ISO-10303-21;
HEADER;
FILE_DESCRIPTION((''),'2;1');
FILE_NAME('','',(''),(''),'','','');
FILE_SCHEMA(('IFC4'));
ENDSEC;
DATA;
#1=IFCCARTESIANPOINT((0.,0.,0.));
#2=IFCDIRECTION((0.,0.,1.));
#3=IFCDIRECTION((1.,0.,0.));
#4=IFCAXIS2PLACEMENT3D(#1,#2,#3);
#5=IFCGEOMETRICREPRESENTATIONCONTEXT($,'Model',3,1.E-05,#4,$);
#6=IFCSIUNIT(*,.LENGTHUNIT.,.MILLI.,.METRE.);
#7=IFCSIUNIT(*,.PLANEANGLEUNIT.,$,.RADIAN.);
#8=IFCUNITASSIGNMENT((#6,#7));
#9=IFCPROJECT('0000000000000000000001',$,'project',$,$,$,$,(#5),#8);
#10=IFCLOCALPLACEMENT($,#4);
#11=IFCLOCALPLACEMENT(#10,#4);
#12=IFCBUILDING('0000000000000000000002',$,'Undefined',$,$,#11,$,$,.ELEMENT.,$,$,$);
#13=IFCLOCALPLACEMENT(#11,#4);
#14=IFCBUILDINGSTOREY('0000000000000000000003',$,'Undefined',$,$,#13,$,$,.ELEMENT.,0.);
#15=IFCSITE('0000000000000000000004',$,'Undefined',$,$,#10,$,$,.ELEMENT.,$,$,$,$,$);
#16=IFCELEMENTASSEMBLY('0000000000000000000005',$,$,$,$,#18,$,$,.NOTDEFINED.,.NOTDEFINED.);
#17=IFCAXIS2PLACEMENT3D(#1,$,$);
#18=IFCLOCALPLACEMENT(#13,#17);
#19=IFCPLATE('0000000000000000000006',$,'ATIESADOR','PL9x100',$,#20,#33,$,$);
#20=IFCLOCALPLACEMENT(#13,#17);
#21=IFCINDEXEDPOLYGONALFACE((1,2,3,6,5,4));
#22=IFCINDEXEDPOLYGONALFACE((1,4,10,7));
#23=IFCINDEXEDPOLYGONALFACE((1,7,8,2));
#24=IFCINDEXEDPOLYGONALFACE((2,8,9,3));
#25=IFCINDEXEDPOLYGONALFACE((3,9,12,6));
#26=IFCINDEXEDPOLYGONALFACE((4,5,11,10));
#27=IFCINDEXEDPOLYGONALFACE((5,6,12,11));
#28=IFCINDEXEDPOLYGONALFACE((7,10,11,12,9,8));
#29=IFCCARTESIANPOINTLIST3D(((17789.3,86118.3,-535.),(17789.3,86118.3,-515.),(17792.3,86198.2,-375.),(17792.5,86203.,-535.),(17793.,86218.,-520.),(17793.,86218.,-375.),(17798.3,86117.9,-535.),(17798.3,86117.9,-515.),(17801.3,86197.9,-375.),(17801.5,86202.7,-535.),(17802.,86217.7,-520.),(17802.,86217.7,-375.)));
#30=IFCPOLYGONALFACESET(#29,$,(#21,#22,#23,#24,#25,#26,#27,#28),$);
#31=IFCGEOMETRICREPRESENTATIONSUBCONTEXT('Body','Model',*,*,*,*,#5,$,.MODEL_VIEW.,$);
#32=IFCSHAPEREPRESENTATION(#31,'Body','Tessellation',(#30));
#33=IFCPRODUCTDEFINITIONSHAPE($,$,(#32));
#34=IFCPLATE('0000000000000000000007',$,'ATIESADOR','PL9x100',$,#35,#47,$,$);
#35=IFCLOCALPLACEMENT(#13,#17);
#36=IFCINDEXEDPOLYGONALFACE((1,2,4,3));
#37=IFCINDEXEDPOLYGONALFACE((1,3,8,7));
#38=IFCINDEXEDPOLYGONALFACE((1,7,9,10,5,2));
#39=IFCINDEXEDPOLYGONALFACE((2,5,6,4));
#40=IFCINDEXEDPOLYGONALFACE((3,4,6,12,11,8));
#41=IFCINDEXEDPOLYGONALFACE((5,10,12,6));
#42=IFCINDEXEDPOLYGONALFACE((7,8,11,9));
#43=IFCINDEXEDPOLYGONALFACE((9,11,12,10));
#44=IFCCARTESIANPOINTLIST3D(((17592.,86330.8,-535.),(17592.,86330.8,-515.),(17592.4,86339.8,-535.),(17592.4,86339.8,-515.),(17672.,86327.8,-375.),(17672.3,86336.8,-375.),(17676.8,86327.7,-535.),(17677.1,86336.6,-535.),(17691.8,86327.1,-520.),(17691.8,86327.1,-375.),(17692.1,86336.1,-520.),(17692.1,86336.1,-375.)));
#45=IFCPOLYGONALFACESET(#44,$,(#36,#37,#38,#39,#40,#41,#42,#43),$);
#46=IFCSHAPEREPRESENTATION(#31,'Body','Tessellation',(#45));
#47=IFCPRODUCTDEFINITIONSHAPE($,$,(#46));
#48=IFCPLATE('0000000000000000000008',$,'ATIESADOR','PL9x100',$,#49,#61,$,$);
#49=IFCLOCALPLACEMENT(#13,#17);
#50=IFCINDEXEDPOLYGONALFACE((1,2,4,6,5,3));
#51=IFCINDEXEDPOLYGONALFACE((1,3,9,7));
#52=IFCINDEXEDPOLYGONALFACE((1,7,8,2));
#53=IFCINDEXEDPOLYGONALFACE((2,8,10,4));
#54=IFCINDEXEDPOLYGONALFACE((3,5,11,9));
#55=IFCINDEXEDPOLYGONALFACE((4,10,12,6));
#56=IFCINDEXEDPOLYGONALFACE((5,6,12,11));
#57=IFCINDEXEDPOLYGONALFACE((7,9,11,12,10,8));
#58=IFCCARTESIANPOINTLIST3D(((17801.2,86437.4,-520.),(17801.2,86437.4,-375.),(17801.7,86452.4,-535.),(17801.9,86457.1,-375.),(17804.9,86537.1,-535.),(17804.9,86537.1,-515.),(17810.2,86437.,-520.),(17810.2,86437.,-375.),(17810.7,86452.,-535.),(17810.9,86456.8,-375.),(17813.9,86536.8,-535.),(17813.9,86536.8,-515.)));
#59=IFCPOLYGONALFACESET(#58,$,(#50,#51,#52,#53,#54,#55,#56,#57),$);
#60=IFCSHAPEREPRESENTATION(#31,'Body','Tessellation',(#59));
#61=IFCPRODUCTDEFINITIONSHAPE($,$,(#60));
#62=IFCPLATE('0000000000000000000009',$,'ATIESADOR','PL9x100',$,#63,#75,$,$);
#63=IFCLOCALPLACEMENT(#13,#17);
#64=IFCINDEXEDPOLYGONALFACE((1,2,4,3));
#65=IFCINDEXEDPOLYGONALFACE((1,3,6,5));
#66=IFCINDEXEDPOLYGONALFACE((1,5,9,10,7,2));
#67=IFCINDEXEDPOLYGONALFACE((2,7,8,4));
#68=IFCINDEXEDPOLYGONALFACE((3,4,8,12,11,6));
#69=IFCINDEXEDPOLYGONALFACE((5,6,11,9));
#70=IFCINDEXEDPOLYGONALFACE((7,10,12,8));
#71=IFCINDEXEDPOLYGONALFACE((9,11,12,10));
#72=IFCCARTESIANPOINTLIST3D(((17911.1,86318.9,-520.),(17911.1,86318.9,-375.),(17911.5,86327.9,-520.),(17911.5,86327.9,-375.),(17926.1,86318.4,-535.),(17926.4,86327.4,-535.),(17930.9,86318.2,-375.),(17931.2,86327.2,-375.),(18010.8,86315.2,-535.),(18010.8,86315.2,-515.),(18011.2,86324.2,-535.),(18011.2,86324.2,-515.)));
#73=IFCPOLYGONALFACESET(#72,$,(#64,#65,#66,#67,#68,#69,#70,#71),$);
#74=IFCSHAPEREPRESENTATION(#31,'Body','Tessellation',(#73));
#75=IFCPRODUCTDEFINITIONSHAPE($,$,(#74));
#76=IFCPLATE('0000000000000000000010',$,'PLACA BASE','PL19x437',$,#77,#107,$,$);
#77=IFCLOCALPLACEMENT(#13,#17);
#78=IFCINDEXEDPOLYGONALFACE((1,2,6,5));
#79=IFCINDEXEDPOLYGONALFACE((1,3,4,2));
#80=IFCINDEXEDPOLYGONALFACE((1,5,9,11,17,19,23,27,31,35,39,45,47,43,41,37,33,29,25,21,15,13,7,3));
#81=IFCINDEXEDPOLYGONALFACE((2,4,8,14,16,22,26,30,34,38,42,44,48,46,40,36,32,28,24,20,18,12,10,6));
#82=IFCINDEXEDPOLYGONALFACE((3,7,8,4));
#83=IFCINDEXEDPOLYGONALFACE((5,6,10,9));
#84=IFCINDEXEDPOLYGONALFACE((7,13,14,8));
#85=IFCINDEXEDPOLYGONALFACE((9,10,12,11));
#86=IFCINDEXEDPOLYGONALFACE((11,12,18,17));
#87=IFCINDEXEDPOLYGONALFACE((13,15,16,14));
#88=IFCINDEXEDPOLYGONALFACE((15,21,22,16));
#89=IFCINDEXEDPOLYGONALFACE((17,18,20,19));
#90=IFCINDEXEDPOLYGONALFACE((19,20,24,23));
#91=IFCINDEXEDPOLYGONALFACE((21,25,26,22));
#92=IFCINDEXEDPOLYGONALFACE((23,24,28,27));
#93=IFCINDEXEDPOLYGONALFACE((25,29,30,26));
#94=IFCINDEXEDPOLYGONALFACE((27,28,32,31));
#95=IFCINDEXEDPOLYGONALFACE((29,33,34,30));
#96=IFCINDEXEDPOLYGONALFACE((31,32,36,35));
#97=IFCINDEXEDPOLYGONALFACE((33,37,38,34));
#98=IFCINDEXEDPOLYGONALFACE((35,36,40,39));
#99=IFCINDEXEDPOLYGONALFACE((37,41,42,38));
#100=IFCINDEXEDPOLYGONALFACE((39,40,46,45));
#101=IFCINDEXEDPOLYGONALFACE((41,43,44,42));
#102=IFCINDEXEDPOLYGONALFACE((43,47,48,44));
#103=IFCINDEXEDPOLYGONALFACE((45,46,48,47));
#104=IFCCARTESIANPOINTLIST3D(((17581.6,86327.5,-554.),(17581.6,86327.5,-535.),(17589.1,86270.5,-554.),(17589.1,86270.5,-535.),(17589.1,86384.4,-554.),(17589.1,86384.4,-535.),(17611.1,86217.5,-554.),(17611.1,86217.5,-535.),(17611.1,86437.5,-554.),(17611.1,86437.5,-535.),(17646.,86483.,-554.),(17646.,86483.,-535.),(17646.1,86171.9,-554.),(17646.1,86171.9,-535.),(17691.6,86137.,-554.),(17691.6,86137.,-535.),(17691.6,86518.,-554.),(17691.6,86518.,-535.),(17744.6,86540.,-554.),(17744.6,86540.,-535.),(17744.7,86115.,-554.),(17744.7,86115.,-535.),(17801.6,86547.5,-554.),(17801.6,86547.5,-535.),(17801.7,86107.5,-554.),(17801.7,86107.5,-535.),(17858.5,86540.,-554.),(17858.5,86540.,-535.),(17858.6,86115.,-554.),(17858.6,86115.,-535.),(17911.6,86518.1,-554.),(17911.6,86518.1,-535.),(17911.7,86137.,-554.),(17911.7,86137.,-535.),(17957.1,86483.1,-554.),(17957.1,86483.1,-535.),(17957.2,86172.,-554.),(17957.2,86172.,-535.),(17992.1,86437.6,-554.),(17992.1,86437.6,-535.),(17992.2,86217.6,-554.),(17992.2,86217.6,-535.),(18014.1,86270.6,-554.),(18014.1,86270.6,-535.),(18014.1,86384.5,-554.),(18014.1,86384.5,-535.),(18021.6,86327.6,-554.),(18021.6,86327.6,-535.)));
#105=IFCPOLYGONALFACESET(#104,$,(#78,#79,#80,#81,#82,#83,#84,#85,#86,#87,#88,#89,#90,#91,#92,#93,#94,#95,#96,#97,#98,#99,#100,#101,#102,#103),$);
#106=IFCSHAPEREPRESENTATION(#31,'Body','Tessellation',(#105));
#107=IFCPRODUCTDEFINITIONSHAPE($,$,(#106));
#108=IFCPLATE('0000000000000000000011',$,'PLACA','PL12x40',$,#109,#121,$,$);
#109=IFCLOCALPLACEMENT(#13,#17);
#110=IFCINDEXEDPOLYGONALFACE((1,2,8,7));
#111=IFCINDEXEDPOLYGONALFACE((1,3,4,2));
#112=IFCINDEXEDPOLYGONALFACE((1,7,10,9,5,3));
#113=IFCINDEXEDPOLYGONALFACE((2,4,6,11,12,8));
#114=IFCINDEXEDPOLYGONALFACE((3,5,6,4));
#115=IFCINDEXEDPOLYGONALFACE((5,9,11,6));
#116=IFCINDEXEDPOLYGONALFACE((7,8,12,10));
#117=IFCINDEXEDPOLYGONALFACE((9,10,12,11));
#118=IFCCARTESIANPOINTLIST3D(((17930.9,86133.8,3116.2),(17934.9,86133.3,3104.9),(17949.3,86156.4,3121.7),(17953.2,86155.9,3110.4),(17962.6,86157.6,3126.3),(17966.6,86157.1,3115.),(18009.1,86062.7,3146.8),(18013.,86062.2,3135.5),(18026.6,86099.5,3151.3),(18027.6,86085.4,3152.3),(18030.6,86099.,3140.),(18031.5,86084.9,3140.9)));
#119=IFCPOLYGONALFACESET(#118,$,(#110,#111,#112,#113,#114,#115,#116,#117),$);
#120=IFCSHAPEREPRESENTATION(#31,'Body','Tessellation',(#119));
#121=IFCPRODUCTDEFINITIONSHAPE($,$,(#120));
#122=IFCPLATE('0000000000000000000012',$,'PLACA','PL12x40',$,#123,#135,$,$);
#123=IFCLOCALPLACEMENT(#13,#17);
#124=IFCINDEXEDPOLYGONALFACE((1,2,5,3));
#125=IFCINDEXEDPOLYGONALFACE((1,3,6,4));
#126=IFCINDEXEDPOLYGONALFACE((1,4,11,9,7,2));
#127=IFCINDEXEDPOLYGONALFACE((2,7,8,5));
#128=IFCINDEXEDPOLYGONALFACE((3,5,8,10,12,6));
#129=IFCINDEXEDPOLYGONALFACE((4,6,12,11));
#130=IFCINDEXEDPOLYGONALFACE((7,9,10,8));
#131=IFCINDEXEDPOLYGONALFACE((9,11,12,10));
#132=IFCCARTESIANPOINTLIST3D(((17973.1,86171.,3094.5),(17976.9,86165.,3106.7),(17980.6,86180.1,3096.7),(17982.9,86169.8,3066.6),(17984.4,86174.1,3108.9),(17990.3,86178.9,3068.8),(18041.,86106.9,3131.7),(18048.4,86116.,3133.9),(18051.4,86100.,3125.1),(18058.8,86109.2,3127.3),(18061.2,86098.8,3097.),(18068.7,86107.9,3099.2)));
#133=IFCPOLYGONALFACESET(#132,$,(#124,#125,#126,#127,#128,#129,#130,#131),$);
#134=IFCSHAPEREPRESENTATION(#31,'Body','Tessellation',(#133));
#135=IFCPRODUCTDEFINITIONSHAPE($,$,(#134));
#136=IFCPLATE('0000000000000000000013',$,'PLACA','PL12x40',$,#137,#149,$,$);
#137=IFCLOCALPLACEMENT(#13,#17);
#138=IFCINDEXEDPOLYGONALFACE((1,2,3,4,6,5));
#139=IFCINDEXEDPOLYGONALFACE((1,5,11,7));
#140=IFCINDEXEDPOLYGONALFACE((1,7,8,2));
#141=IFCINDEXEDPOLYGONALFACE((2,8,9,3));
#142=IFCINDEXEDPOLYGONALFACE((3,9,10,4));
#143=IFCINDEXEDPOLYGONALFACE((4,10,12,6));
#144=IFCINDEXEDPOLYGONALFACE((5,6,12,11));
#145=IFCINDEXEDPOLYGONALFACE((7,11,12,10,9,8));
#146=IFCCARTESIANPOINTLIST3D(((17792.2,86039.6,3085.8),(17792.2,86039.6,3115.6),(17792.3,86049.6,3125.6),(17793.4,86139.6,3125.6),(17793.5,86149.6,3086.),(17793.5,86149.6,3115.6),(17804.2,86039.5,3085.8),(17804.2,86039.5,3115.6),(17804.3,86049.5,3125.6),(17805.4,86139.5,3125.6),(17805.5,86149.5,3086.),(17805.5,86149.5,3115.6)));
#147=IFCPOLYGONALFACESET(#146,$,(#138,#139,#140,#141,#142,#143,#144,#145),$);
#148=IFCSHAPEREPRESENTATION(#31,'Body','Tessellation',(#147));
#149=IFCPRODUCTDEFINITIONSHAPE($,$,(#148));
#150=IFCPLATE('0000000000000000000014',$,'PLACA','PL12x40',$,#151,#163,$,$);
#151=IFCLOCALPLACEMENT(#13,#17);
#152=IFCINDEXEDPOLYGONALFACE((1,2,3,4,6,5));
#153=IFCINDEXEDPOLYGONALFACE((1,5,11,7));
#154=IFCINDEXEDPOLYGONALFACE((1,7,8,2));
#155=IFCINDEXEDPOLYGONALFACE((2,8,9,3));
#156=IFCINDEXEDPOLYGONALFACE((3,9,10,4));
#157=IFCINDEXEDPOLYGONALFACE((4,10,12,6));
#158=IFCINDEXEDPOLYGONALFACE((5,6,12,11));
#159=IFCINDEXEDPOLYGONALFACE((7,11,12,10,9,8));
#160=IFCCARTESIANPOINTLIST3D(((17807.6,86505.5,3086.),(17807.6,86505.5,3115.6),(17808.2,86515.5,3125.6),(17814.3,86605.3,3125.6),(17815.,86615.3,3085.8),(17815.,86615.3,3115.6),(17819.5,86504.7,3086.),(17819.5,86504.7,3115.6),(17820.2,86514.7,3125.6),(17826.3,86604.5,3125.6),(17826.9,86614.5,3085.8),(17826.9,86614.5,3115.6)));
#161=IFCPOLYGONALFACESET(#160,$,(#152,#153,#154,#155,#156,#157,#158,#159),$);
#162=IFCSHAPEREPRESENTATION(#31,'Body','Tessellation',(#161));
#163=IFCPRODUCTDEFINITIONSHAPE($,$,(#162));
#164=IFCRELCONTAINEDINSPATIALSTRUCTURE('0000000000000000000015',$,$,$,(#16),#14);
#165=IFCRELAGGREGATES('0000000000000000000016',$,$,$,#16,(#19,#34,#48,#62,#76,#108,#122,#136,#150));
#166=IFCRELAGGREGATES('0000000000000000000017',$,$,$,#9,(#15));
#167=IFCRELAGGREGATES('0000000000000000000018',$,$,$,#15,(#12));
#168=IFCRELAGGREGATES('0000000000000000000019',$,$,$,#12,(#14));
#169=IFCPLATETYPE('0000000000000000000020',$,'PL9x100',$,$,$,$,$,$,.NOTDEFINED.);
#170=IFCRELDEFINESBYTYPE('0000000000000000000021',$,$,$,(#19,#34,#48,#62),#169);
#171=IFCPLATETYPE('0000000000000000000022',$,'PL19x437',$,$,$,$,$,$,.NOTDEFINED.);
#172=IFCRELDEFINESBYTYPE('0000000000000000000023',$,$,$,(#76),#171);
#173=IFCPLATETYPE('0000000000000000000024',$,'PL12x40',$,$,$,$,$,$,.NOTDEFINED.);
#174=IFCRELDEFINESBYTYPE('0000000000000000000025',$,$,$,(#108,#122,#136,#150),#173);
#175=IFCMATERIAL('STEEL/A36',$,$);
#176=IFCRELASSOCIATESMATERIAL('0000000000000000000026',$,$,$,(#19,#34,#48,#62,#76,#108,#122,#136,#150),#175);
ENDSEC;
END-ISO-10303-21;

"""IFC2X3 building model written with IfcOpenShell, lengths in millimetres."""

from ifc_helpers import new_model, si_unit, frame, frame_2d, origin_with_axes, place, context, subcontext, project, spatial, polyline, circle_curve, parameter, trimmed, segment, composite_curve, outline, extrude, material, type_object, element, aggregate, save


model = new_model("IFC2X3")

# Units and contexts
model_context = context("Model", 3, precision=1e-05, world=origin_with_axes())
body_context = subcontext(model_context, "Body", "Model", "MODEL_VIEW")
ifc_project = project(units=[si_unit("LENGTHUNIT", "METRE", prefix="MILLI"), si_unit("PLANEANGLEUNIT", "RADIAN")], contexts=[model_context])

# Site, building, storey
site_placement = place(None, origin_with_axes())
site = spatial("IfcSite", under=ifc_project, at=site_placement, Name="Undefined", CompositionType="ELEMENT")
building_placement = place(site_placement, origin_with_axes())
building = spatial("IfcBuilding", under=site, at=building_placement, Name="Undefined", CompositionType="ELEMENT")
storey_placement = place(building_placement, origin_with_axes())
storey = spatial("IfcBuildingStorey", under=building, at=storey_placement, Name="Undefined", CompositionType="ELEMENT", Elevation=0.0)

# Element assembly, plates
assembly_1_placement = place(storey_placement, origin_with_axes())
assembly_1 = element("IfcElementAssembly", 1, at=assembly_1_placement, inside=storey, AssemblyPlace="NOTDEFINED", PredefinedType="NOTDEFINED")
ifc_material_1 = material(Name="STEEL/A36")
plate_type_1 = type_object("IfcPlateType", Name="PL9x100", PredefinedType="NOTDEFINED")
plate_1_placement = place(assembly_1_placement, frame((17793.8, 86118.1, -515.0), z_axis=(0.999309, -0.037178, 0.0), x_axis=(0.0, 0.0, -1.0)))
plate_1 = element("IfcPlate", 2, at=plate_1_placement, type_object=plate_type_1, material=ifc_material_1, Name="ATIESADOR", Description="PL9x100", context=body_context, shape_type="SweptSolid", body=[
    extrude(outline(polyline([(0.0, 0.0), (20.0, 0.0), (20.0, 84.8), (5.0, 99.8), (-140.0, 99.8), (-140.0, 80.0), (0.0, 0.0)])), frame((0.0, 0.0, -4.5), z_axis=(0.0, 0.0, 1.0), x_axis=(1.0, 0.0, 0.0)), (0.0, 0.0, 1.0), 9.0),
])
plate_2_placement = place(assembly_1_placement, frame((17592.2, 86335.3, -515.0), z_axis=(-0.037178, -0.999309, 0.0), x_axis=(0.0, 0.0, -1.0)))
plate_2 = element("IfcPlate", 3, at=plate_2_placement, type_object=plate_type_1, material=ifc_material_1, Name="ATIESADOR", Description="PL9x100", context=body_context, shape_type="SweptSolid", body=[
    extrude(outline(polyline([(0.0, 0.0), (20.0, 0.0), (20.0, 84.8), (5.0, 99.8), (-140.0, 99.8), (-140.0, 80.0), (0.0, 0.0)])), frame((0.0, 0.0, -4.5), z_axis=(0.0, 0.0, 1.0), x_axis=(1.0, 0.0, 0.0)), (0.0, 0.0, 1.0), 9.0),
])
plate_3_placement = place(assembly_1_placement, frame((17809.4, 86536.9, -515.0), z_axis=(-0.999309, 0.037178, 0.0), x_axis=(0.0, 0.0, -1.0)))
plate_3 = element("IfcPlate", 4, at=plate_3_placement, type_object=plate_type_1, material=ifc_material_1, Name="ATIESADOR", Description="PL9x100", context=body_context, shape_type="SweptSolid", body=[
    extrude(outline(polyline([(0.0, 0.0), (20.0, 0.0), (20.0, 84.8), (5.0, 99.8), (-140.0, 99.8), (-140.0, 80.0), (0.0, 0.0)])), frame((0.0, 0.0, -4.5), z_axis=(0.0, 0.0, 1.0), x_axis=(1.0, 0.0, 0.0)), (0.0, 0.0, 1.0), 9.0),
])
plate_4_placement = place(assembly_1_placement, frame((18011.0, 86319.7, -515.0), z_axis=(0.037178, 0.999309, 0.0), x_axis=(0.0, 0.0, -1.0)))
plate_4 = element("IfcPlate", 5, at=plate_4_placement, type_object=plate_type_1, material=ifc_material_1, Name="ATIESADOR", Description="PL9x100", context=body_context, shape_type="SweptSolid", body=[
    extrude(outline(polyline([(0.0, 0.0), (20.0, 0.0), (20.0, 84.8), (5.0, 99.8), (-140.0, 99.8), (-140.0, 80.0), (0.0, 0.0)])), frame((0.0, 0.0, -4.5), z_axis=(0.0, 0.0, 1.0), x_axis=(1.0, 0.0, 0.0)), (0.0, 0.0, 1.0), 9.0),
])
plate_type_2 = type_object("IfcPlateType", Name="PL19x437", PredefinedType="NOTDEFINED")
plate_5_placement = place(assembly_1_placement, frame((17858.5, 86540.0, -544.5), z_axis=(0.0, 0.0, 1.0), x_axis=(-0.865912, -0.500196, 0.0)))
plate_5 = element("IfcPlate", 6, at=plate_5_placement, type_object=plate_type_2, material=ifc_material_1, Name="PLACA BASE", Description="PL19x437", context=body_context, shape_type="SweptSolid", body=[
    extrude(outline(composite_curve([segment(trimmed(circle_curve(frame_2d((155.6, 155.6), x_axis=(-1.0, 0.000003)), 220.0), [parameter(0.0)], [parameter(1.570799)], True, "PARAMETER"), True, "CONTINUOUS"), segment(trimmed(circle_curve(frame_2d((155.6, 155.6), x_axis=(0.0, -1.0)), 220.0), [parameter(0.0)], [parameter(1.570794)], True, "PARAMETER"), True, "CONTINUOUS"), segment(trimmed(circle_curve(frame_2d((155.6, 155.6), x_axis=(1.0, -0.000003)), 220.0), [parameter(0.0)], [parameter(1.5708)], True, "PARAMETER"), True, "CONTINUOUS"), segment(trimmed(circle_curve(frame_2d((155.6, 155.6), x_axis=(-0.000001, 1.0)), 220.0), [parameter(0.0)], [parameter(1.570793)], True, "PARAMETER"), True, "DISCONTINUOUS")], self_intersect=True)), frame((0.0, 0.0, -9.5), z_axis=(0.0, 0.0, 1.0), x_axis=(1.0, 0.0, 0.0)), (0.0, 0.0, 1.0), 19.0),
])
plate_type_3 = type_object("IfcPlateType", Name="PL12x40", PredefinedType="NOTDEFINED")
plate_6_placement = place(assembly_1_placement, frame((18011.1, 86062.5, 3141.1), z_axis=(-0.330461, 0.041741, 0.942896), x_axis=(0.620011, 0.762826, 0.183528)))
plate_6 = element("IfcPlate", 7, at=plate_6_placement, type_object=plate_type_3, material=ifc_material_1, Name="PLACA", Description="PL12x40", context=body_context, shape_type="SweptSolid", body=[
    extrude(outline(polyline([(0.0, 0.0), (29.8, 0.0), (39.8, 10.0), (39.8, 100.0), (29.8, 110.0), (0.2, 110.0), (0.0, 0.0)])), frame((0.0, 0.0, -6.0), z_axis=(0.0, 0.0, 1.0), x_axis=(1.0, 0.0, 0.0)), (0.0, 0.0, 1.0), 12.0),
])
plate_7_placement = place(assembly_1_placement, frame((18065.0, 86103.3, 3098.1), z_axis=(-0.620011, -0.762826, -0.183528), x_axis=(-0.330461, 0.041741, 0.942896)))
plate_7 = element("IfcPlate", 8, at=plate_7_placement, type_object=plate_type_3, material=ifc_material_1, Name="PLACA", Description="PL12x40", context=body_context, shape_type="SweptSolid", body=[
    extrude(outline(polyline([(0.0, 0.0), (29.8, 0.0), (39.8, 10.0), (39.8, 100.0), (29.8, 110.0), (0.2, 110.0), (0.0, 0.0)])), frame((0.0, 0.0, -6.0), z_axis=(0.0, 0.0, 1.0), x_axis=(1.0, 0.0, 0.0)), (0.0, 0.0, 1.0), 12.0),
])
plate_8_placement = place(assembly_1_placement, frame((17798.2, 86039.5, 3085.8), z_axis=(-0.99993, 0.011839, 0.0), x_axis=(0.0, 0.0, 1.0)))
plate_8 = element("IfcPlate", 9, at=plate_8_placement, type_object=plate_type_3, material=ifc_material_1, Name="PLACA", Description="PL12x40", context=body_context, shape_type="SweptSolid", body=[
    extrude(outline(polyline([(0.0, 0.0), (29.8, 0.0), (39.8, 10.0), (39.8, 100.0), (29.8, 110.0), (0.2, 110.0), (0.0, 0.0)])), frame((0.0, 0.0, -6.0), z_axis=(0.0, 0.0, 1.0), x_axis=(1.0, 0.0, 0.0)), (0.0, 0.0, 1.0), 12.0),
])
plate_9_placement = place(assembly_1_placement, frame((17820.9, 86614.9, 3085.8), z_axis=(0.997745, -0.067123, 0.0), x_axis=(0.0, 0.0, 1.0)))
plate_9 = element("IfcPlate", 10, at=plate_9_placement, type_object=plate_type_3, material=ifc_material_1, Name="PLACA", Description="PL12x40", context=body_context, shape_type="SweptSolid", body=[
    extrude(outline(polyline([(0.0, 0.0), (29.8, 0.0), (39.8, 10.0), (39.8, 100.0), (29.8, 110.0), (0.2, 110.0), (0.0, 0.0)])), frame((0.0, 0.0, -6.0), z_axis=(0.0, 0.0, 1.0), x_axis=(1.0, 0.0, 0.0)), (0.0, 0.0, 1.0), 12.0),
])

aggregate(assembly_1, [plate_1, plate_2, plate_3, plate_4, plate_5, plate_6, plate_7, plate_8, plate_9])

save(model, "model.ifc")
